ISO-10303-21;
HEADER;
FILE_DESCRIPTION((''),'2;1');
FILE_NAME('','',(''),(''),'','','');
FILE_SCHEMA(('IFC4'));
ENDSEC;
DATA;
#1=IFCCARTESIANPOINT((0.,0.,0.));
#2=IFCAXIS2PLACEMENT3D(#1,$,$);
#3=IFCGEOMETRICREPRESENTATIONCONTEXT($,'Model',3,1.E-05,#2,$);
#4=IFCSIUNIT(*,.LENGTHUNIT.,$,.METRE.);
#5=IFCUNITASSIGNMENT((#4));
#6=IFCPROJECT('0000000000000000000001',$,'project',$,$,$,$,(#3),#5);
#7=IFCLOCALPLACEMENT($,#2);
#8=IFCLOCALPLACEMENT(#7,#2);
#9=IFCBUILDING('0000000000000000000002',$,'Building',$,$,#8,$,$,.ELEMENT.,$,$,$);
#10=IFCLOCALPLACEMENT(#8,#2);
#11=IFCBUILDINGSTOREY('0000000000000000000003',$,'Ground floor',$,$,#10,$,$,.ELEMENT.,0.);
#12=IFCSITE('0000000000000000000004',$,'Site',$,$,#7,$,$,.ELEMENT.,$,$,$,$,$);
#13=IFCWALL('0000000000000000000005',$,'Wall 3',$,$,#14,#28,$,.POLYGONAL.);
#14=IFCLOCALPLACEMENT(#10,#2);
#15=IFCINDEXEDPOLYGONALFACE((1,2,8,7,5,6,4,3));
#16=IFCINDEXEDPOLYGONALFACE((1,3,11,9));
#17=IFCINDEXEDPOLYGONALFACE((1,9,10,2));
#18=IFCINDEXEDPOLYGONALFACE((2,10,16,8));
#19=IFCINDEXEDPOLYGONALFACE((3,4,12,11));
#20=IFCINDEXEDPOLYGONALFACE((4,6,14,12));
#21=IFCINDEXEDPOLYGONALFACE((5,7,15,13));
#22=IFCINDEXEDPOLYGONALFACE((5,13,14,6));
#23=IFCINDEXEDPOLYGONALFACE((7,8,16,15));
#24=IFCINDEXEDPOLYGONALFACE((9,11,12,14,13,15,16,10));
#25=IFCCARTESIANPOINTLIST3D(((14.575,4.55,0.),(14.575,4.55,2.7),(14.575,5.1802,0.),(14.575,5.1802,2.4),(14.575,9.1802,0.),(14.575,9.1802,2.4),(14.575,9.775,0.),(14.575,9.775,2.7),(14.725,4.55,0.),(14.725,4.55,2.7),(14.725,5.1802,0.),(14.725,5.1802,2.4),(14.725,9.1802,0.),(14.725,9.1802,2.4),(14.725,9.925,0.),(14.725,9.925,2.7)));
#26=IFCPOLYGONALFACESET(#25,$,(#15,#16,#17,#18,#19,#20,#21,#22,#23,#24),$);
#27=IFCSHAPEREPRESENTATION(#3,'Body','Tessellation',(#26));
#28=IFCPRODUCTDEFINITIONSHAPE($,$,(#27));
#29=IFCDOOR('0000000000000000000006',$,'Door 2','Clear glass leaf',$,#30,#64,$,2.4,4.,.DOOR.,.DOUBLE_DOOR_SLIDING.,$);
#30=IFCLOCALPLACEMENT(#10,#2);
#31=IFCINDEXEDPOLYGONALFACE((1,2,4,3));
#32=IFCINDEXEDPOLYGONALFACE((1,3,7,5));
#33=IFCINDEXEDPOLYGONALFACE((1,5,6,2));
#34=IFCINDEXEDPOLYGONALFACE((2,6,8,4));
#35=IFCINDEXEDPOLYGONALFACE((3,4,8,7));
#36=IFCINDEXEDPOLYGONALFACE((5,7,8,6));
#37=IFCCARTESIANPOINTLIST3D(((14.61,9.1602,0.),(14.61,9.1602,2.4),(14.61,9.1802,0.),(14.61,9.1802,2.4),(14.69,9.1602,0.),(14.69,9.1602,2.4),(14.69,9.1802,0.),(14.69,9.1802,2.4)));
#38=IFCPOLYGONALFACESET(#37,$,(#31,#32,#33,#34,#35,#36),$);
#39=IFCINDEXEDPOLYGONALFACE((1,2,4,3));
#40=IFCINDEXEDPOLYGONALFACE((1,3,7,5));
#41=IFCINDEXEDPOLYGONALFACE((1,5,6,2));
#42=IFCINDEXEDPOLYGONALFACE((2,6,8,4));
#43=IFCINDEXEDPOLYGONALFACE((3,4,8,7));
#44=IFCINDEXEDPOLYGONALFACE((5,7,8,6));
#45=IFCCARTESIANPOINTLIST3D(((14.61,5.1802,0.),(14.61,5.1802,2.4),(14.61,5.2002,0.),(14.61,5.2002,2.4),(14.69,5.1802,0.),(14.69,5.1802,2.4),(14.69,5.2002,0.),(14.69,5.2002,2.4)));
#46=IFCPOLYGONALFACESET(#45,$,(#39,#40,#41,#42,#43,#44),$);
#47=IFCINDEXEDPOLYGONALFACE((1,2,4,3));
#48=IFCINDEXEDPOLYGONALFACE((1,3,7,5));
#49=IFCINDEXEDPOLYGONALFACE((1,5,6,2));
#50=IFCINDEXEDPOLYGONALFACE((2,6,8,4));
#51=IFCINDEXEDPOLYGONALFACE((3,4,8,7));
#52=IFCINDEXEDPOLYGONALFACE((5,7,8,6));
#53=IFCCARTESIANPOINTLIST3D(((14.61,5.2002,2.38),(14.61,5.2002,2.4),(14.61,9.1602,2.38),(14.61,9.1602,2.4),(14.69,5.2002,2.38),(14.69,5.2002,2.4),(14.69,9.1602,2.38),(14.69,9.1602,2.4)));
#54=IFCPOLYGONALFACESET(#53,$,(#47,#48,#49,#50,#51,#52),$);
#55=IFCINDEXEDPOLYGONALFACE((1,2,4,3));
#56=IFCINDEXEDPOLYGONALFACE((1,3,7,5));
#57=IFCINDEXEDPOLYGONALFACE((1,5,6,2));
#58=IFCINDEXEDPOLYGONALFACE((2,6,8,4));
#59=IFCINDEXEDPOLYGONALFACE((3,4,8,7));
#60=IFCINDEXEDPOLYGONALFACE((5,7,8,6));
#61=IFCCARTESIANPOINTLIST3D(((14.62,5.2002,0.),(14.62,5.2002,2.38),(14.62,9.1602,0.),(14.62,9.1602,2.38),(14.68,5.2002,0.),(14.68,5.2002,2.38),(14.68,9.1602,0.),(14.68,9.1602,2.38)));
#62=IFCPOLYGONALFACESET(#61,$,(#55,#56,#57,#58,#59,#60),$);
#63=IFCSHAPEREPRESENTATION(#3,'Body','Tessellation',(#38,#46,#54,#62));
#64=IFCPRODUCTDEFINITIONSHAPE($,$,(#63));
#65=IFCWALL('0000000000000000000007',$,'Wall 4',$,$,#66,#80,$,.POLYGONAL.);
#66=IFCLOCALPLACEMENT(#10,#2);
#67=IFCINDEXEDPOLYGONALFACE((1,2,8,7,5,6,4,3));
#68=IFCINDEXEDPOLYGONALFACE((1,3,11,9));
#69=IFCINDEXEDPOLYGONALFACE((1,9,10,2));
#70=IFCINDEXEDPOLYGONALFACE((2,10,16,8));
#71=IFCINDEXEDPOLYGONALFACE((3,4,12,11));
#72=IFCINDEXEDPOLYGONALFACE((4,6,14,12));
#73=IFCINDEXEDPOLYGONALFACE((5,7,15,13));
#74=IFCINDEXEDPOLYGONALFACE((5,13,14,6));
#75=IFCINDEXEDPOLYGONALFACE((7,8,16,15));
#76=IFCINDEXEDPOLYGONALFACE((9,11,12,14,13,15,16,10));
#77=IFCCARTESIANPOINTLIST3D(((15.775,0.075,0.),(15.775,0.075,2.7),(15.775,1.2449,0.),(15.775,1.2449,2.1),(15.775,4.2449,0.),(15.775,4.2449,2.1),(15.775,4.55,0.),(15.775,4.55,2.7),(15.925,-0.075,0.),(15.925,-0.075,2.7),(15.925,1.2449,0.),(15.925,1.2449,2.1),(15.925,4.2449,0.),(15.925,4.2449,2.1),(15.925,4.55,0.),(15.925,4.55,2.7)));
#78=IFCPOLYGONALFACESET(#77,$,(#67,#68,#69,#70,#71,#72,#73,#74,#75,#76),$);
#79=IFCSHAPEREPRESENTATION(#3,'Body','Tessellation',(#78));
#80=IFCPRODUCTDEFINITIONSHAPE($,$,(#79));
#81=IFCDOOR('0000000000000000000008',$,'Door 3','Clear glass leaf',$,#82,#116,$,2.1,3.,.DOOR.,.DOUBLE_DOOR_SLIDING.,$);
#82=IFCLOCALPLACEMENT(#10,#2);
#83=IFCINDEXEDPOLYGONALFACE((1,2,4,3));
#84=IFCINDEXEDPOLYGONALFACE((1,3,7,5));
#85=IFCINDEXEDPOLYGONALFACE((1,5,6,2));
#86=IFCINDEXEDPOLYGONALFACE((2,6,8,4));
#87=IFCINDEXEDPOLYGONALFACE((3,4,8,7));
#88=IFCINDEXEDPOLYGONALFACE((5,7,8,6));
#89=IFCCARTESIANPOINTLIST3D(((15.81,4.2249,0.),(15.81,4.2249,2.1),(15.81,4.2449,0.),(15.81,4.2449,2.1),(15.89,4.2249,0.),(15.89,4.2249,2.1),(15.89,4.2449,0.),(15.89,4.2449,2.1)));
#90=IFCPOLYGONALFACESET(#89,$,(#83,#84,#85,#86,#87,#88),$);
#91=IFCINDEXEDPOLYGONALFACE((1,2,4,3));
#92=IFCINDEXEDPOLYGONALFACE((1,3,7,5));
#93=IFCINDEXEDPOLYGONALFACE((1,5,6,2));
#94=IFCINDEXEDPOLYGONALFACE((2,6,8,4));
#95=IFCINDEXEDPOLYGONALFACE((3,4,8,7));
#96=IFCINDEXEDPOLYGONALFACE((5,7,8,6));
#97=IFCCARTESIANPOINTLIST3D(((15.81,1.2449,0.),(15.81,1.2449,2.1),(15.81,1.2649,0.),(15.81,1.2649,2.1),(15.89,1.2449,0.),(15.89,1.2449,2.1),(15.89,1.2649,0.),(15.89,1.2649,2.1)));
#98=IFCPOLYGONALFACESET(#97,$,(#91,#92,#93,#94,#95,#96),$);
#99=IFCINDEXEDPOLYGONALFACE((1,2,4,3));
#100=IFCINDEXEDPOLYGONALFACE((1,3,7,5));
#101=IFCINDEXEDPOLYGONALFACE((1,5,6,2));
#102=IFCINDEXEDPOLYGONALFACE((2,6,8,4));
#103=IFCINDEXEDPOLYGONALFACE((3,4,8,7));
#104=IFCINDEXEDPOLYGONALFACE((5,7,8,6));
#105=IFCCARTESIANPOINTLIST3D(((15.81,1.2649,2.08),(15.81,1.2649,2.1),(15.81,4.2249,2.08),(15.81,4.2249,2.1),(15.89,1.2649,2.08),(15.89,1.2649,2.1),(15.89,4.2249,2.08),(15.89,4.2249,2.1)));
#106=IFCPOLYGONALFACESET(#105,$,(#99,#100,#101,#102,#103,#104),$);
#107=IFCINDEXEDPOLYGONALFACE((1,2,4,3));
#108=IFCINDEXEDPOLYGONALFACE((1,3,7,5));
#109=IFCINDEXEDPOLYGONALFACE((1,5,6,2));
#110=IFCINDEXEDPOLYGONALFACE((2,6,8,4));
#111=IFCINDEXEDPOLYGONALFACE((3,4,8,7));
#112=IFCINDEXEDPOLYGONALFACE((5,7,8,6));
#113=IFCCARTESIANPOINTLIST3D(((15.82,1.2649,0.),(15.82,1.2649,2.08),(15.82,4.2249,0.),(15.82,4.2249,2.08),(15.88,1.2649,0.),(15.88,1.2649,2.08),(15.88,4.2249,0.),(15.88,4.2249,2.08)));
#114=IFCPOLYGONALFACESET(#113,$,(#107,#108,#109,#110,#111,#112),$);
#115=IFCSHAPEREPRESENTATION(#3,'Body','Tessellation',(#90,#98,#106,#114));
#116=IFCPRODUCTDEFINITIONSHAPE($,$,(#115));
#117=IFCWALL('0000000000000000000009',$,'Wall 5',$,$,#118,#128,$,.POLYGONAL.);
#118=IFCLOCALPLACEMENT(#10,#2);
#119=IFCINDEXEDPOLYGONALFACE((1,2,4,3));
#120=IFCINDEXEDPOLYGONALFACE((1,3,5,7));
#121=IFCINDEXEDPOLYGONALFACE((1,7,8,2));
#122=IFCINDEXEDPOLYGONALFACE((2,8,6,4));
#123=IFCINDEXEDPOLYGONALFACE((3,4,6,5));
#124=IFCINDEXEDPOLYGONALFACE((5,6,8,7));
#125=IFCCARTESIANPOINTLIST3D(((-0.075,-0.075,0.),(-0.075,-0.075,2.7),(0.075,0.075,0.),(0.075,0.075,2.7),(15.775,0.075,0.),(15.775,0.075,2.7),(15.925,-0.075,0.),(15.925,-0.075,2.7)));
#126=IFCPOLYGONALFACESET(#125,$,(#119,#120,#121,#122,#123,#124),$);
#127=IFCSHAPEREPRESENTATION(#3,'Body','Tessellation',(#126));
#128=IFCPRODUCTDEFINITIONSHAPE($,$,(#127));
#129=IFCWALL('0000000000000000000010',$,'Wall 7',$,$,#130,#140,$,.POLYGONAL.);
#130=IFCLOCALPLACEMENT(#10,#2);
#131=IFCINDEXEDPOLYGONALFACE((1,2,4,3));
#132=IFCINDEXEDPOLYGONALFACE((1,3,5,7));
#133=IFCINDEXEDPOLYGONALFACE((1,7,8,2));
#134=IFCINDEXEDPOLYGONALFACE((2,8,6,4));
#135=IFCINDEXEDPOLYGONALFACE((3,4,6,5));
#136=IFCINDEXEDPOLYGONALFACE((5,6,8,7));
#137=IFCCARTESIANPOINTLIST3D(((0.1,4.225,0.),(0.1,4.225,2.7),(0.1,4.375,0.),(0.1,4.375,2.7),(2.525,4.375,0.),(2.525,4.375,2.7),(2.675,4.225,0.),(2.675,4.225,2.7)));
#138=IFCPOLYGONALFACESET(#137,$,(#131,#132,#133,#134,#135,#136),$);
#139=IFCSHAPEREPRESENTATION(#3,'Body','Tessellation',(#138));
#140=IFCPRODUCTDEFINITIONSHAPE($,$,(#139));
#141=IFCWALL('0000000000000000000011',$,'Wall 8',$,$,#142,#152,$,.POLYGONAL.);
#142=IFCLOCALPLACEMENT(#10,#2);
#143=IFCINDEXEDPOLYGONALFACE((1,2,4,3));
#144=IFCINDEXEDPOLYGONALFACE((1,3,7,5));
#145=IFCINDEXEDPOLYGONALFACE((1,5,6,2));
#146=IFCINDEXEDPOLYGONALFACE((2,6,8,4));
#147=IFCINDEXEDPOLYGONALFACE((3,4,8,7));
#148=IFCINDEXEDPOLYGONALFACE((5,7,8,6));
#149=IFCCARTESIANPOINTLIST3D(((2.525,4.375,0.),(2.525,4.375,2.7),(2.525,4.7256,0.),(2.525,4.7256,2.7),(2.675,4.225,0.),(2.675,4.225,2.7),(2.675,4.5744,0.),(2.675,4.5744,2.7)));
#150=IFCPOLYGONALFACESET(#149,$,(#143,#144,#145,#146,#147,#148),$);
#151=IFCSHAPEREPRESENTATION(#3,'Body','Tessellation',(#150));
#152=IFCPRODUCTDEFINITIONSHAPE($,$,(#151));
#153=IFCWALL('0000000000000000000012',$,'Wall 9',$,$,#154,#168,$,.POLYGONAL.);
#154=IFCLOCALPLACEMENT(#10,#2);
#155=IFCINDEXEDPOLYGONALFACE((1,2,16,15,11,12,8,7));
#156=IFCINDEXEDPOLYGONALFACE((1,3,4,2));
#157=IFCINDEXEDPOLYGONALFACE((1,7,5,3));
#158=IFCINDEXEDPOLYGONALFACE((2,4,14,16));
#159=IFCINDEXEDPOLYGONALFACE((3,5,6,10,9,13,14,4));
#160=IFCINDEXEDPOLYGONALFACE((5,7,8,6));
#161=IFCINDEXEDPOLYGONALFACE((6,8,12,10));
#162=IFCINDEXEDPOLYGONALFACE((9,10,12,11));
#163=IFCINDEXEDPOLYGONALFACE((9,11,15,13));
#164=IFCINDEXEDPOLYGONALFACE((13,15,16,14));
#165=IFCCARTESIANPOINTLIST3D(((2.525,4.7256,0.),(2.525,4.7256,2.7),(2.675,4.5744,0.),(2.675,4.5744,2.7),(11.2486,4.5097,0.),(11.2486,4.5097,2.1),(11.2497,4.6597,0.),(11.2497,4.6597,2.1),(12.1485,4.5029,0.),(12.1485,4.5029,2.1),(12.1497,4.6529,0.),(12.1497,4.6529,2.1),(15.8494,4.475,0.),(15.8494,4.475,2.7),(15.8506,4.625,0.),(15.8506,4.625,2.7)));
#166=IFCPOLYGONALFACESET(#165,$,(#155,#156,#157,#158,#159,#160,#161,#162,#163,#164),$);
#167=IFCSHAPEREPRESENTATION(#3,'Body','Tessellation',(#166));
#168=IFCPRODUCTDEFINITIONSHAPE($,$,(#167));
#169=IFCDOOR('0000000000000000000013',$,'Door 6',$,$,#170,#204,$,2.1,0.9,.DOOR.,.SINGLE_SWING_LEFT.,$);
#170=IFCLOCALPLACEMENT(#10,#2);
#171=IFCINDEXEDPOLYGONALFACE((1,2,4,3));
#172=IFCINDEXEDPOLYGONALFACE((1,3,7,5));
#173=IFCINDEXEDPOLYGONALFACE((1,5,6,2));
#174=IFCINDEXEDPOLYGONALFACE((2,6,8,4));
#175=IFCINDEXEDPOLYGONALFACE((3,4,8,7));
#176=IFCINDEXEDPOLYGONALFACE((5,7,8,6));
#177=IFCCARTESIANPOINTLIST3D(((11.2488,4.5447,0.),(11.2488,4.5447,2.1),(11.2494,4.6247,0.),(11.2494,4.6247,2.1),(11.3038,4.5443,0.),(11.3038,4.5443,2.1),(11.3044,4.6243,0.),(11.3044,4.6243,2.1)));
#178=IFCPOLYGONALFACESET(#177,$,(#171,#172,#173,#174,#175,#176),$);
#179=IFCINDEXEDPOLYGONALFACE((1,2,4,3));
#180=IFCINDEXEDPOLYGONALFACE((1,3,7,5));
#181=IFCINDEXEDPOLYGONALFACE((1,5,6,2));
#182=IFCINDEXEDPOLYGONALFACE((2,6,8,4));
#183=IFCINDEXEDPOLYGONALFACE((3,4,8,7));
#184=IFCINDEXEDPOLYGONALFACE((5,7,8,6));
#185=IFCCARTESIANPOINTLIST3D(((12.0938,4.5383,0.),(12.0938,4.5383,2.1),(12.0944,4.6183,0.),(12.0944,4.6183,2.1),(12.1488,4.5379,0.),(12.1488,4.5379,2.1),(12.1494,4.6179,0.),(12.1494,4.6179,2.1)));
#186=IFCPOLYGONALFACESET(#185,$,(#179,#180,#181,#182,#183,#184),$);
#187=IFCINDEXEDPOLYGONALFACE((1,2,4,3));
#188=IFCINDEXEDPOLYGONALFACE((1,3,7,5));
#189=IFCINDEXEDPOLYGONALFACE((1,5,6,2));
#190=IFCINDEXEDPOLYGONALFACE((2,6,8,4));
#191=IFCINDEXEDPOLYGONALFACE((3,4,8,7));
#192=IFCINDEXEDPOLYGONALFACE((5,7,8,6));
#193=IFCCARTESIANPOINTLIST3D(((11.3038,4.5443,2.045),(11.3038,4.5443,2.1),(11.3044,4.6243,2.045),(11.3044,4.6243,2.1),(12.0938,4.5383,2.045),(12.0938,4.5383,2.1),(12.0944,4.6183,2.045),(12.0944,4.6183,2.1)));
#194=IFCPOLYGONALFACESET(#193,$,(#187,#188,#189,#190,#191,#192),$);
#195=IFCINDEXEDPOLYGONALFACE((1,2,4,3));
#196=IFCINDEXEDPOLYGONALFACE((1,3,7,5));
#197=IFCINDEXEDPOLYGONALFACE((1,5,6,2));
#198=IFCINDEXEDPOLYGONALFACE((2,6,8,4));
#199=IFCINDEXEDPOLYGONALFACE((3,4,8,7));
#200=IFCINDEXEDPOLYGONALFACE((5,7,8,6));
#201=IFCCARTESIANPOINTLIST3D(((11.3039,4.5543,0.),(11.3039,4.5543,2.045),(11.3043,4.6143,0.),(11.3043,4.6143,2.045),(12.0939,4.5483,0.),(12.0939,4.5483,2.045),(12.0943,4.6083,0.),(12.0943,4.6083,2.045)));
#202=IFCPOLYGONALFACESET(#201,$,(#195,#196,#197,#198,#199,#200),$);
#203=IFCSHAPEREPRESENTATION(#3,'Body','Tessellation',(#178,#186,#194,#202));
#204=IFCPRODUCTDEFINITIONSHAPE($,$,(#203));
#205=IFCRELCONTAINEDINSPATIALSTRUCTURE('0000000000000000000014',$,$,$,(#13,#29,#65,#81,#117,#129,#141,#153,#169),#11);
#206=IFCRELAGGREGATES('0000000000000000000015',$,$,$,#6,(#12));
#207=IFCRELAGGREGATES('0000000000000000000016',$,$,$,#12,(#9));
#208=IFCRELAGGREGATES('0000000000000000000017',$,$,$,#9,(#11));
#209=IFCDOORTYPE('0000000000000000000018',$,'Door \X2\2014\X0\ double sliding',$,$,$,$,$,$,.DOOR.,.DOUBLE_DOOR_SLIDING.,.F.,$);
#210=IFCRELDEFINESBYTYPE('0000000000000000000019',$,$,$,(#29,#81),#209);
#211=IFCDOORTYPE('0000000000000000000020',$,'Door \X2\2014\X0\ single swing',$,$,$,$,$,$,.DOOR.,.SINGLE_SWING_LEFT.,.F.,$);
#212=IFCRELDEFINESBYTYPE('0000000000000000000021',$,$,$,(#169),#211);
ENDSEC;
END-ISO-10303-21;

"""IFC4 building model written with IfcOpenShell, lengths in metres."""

from ifc_helpers import new_model, si_unit, frame, frame_2d, origin, origin_with_axes, place, context, project, spatial, polyline, rectangle, outline, extrude, type_object, element, fill, save


model = new_model("IFC4")

# Units and contexts
model_context = context("Model", 3, precision=1e-05, world=origin())
ifc_project = project(units=[si_unit("LENGTHUNIT", "METRE")], contexts=[model_context])

# Site, building, storey
site_placement = place(None, origin())
site = spatial("IfcSite", under=ifc_project, at=site_placement, Name="Site", CompositionType="ELEMENT")
building_placement = place(site_placement, origin())
building = spatial("IfcBuilding", under=site, at=building_placement, Name="Building", CompositionType="ELEMENT")
storey_placement = place(building_placement, origin())
storey = spatial("IfcBuildingStorey", under=building, at=storey_placement, Name="Ground floor", CompositionType="ELEMENT", Elevation=0.0)

# Shared definitions
door_type_1 = type_object("IfcDoorType", Name="Door — single swing", OperationType="SINGLE_SWING_LEFT", ParameterTakesPrecedence=False, PredefinedType="DOOR")

# Walls, openings, doors
wall_1_placement = place(storey_placement, origin_with_axes())
wall_1 = element("IfcWall", 1, at=wall_1_placement, inside=storey, Name="Wall 3", PredefinedType="POLYGONAL", context=model_context, shape_type="SweptSolid", body=[
    extrude(outline(polyline([(14.725, 9.925), (14.575, 9.775), (14.575, 4.55), (14.725, 4.55), (14.725, 9.925)])), origin(), (0.0, 0.0, 1.0), 2.7),
])
opening_1_placement = place(storey_placement, frame((14.65, 9.1802, 0.0), z_axis=(0.0, 0.0, 1.0), x_axis=(0.0, -1.0, 0.0)))
opening_1 = element("IfcOpeningElement", 2, at=opening_1_placement, cuts=wall_1, PredefinedType="OPENING", context=model_context, shape_type="SweptSolid", body=[
    extrude(rectangle(XDim=4.0, YDim=0.21, at=frame_2d((2.0, 0.0))), origin(), (0.0, 0.0, 1.0), 2.4),
])
door_type_2 = type_object("IfcDoorType", Name="Door — double sliding", OperationType="DOUBLE_DOOR_SLIDING", ParameterTakesPrecedence=False, PredefinedType="DOOR")
door_1_placement = place(storey_placement, frame((14.65, 9.1802, 0.0), z_axis=(0.0, 0.0, 1.0), x_axis=(0.0, -1.0, 0.0)))
door_1 = element("IfcDoor", 3, at=door_1_placement, inside=storey, type_object=door_type_2, Name="Door 2", Description="Clear glass leaf", OperationType="DOUBLE_DOOR_SLIDING", OverallHeight=2.4, OverallWidth=4.0, PredefinedType="DOOR", context=model_context, shape_type="SweptSolid", body=[
    extrude(rectangle(XDim=0.02, YDim=0.08, at=frame_2d((0.01, 0.0))), origin(), (0.0, 0.0, 1.0), 2.4),
    extrude(rectangle(XDim=0.02, YDim=0.08, at=frame_2d((3.99, 0.0))), origin(), (0.0, 0.0, 1.0), 2.4),
    extrude(rectangle(XDim=3.96, YDim=0.08, at=frame_2d((2.0, 0.0))), frame((0.0, 0.0, 2.38)), (0.0, 0.0, 1.0), 0.02),
    extrude(rectangle(XDim=3.96, YDim=0.06, at=frame_2d((2.0, 0.0))), origin(), (0.0, 0.0, 1.0), 2.38),
])
fill(opening_1, door_1)
wall_2_placement = place(storey_placement, origin_with_axes())
wall_2 = element("IfcWall", 4, at=wall_2_placement, inside=storey, Name="Wall 4", PredefinedType="POLYGONAL", context=model_context, shape_type="SweptSolid", body=[
    extrude(outline(polyline([(15.925, 4.55), (15.775, 4.55), (15.775, 0.075), (15.925, -0.075), (15.925, 4.55)])), origin(), (0.0, 0.0, 1.0), 2.7),
])
opening_2_placement = place(storey_placement, frame((15.85, 4.2449, 0.0), z_axis=(0.0, 0.0, 1.0), x_axis=(0.0, -1.0, 0.0)))
opening_2 = element("IfcOpeningElement", 5, at=opening_2_placement, cuts=wall_2, PredefinedType="OPENING", context=model_context, shape_type="SweptSolid", body=[
    extrude(rectangle(XDim=3.0, YDim=0.21, at=frame_2d((1.5, 0.0))), origin(), (0.0, 0.0, 1.0), 2.1),
])
door_2_placement = place(storey_placement, frame((15.85, 4.2449, 0.0), z_axis=(0.0, 0.0, 1.0), x_axis=(0.0, -1.0, 0.0)))
door_2 = element("IfcDoor", 6, at=door_2_placement, inside=storey, type_object=door_type_2, Name="Door 3", Description="Clear glass leaf", OperationType="DOUBLE_DOOR_SLIDING", OverallHeight=2.1, OverallWidth=3.0, PredefinedType="DOOR", context=model_context, shape_type="SweptSolid", body=[
    extrude(rectangle(XDim=0.02, YDim=0.08, at=frame_2d((0.01, 0.0))), origin(), (0.0, 0.0, 1.0), 2.1),
    extrude(rectangle(XDim=0.02, YDim=0.08, at=frame_2d((2.99, 0.0))), origin(), (0.0, 0.0, 1.0), 2.1),
    extrude(rectangle(XDim=2.96, YDim=0.08, at=frame_2d((1.5, 0.0))), frame((0.0, 0.0, 2.08)), (0.0, 0.0, 1.0), 0.02),
    extrude(rectangle(XDim=2.96, YDim=0.06, at=frame_2d((1.5, 0.0))), origin(), (0.0, 0.0, 1.0), 2.08),
])
fill(opening_2, door_2)

# Walls
wall_3_placement = place(storey_placement, origin_with_axes())
element("IfcWall", 7, at=wall_3_placement, inside=storey, Name="Wall 5", PredefinedType="POLYGONAL", context=model_context, shape_type="SweptSolid", body=[
    extrude(outline(polyline([(15.925, -0.075), (15.775, 0.075), (0.075, 0.075), (-0.075, -0.075), (15.925, -0.075)])), origin(), (0.0, 0.0, 1.0), 2.7),
])
wall_4_placement = place(storey_placement, origin_with_axes())
element("IfcWall", 8, at=wall_4_placement, inside=storey, Name="Wall 7", PredefinedType="POLYGONAL", context=model_context, shape_type="SweptSolid", body=[
    extrude(outline(polyline([(0.1, 4.375), (0.1, 4.225), (2.675, 4.225), (2.525, 4.375), (0.1, 4.375)])), origin(), (0.0, 0.0, 1.0), 2.7),
])
wall_5_placement = place(storey_placement, origin_with_axes())
element("IfcWall", 9, at=wall_5_placement, inside=storey, Name="Wall 8", PredefinedType="POLYGONAL", context=model_context, shape_type="SweptSolid", body=[
    extrude(outline(polyline([(2.525, 4.375), (2.675, 4.225), (2.675, 4.5744), (2.525, 4.7256), (2.525, 4.375)])), origin(), (0.0, 0.0, 1.0), 2.7),
])

# Wall, opening, door
wall_6_placement = place(storey_placement, origin_with_axes())
wall_6 = element("IfcWall", 10, at=wall_6_placement, inside=storey, Name="Wall 9", PredefinedType="POLYGONAL", context=model_context, shape_type="SweptSolid", body=[
    extrude(outline(polyline([(2.525, 4.7256), (2.675, 4.5744), (15.8494, 4.475), (15.8506, 4.625), (2.525, 4.7256)])), origin(), (0.0, 0.0, 1.0), 2.7),
])
opening_3_placement = place(storey_placement, frame((11.2491, 4.5847, 0.0), z_axis=(0.0, 0.0, 1.0), x_axis=(0.999972, -0.007547, 0.0)))
opening_3 = element("IfcOpeningElement", 11, at=opening_3_placement, cuts=wall_6, PredefinedType="OPENING", context=model_context, shape_type="SweptSolid", body=[
    extrude(rectangle(XDim=0.9, YDim=0.21, at=frame_2d((0.45, 0.0))), origin(), (0.0, 0.0, 1.0), 2.1),
])
door_3_placement = place(storey_placement, frame((11.2491, 4.5847, 0.0), z_axis=(0.0, 0.0, 1.0), x_axis=(0.999972, -0.007547, 0.0)))
door_3 = element("IfcDoor", 12, at=door_3_placement, inside=storey, type_object=door_type_1, Name="Door 6", OperationType="SINGLE_SWING_LEFT", OverallHeight=2.1, OverallWidth=0.9, PredefinedType="DOOR", context=model_context, shape_type="SweptSolid", body=[
    extrude(rectangle(XDim=0.055, YDim=0.08, at=frame_2d((0.0275, 0.0))), origin(), (0.0, 0.0, 1.0), 2.1),
    extrude(rectangle(XDim=0.055, YDim=0.08, at=frame_2d((0.8725, 0.0))), origin(), (0.0, 0.0, 1.0), 2.1),
    extrude(rectangle(XDim=0.79, YDim=0.08, at=frame_2d((0.45, 0.0))), frame((0.0, 0.0, 2.045)), (0.0, 0.0, 1.0), 0.055),
    extrude(rectangle(XDim=0.79, YDim=0.06, at=frame_2d((0.45, 0.0))), origin(), (0.0, 0.0, 1.0), 2.045),
])
fill(opening_3, door_3)

save(model, "model.ifc")
